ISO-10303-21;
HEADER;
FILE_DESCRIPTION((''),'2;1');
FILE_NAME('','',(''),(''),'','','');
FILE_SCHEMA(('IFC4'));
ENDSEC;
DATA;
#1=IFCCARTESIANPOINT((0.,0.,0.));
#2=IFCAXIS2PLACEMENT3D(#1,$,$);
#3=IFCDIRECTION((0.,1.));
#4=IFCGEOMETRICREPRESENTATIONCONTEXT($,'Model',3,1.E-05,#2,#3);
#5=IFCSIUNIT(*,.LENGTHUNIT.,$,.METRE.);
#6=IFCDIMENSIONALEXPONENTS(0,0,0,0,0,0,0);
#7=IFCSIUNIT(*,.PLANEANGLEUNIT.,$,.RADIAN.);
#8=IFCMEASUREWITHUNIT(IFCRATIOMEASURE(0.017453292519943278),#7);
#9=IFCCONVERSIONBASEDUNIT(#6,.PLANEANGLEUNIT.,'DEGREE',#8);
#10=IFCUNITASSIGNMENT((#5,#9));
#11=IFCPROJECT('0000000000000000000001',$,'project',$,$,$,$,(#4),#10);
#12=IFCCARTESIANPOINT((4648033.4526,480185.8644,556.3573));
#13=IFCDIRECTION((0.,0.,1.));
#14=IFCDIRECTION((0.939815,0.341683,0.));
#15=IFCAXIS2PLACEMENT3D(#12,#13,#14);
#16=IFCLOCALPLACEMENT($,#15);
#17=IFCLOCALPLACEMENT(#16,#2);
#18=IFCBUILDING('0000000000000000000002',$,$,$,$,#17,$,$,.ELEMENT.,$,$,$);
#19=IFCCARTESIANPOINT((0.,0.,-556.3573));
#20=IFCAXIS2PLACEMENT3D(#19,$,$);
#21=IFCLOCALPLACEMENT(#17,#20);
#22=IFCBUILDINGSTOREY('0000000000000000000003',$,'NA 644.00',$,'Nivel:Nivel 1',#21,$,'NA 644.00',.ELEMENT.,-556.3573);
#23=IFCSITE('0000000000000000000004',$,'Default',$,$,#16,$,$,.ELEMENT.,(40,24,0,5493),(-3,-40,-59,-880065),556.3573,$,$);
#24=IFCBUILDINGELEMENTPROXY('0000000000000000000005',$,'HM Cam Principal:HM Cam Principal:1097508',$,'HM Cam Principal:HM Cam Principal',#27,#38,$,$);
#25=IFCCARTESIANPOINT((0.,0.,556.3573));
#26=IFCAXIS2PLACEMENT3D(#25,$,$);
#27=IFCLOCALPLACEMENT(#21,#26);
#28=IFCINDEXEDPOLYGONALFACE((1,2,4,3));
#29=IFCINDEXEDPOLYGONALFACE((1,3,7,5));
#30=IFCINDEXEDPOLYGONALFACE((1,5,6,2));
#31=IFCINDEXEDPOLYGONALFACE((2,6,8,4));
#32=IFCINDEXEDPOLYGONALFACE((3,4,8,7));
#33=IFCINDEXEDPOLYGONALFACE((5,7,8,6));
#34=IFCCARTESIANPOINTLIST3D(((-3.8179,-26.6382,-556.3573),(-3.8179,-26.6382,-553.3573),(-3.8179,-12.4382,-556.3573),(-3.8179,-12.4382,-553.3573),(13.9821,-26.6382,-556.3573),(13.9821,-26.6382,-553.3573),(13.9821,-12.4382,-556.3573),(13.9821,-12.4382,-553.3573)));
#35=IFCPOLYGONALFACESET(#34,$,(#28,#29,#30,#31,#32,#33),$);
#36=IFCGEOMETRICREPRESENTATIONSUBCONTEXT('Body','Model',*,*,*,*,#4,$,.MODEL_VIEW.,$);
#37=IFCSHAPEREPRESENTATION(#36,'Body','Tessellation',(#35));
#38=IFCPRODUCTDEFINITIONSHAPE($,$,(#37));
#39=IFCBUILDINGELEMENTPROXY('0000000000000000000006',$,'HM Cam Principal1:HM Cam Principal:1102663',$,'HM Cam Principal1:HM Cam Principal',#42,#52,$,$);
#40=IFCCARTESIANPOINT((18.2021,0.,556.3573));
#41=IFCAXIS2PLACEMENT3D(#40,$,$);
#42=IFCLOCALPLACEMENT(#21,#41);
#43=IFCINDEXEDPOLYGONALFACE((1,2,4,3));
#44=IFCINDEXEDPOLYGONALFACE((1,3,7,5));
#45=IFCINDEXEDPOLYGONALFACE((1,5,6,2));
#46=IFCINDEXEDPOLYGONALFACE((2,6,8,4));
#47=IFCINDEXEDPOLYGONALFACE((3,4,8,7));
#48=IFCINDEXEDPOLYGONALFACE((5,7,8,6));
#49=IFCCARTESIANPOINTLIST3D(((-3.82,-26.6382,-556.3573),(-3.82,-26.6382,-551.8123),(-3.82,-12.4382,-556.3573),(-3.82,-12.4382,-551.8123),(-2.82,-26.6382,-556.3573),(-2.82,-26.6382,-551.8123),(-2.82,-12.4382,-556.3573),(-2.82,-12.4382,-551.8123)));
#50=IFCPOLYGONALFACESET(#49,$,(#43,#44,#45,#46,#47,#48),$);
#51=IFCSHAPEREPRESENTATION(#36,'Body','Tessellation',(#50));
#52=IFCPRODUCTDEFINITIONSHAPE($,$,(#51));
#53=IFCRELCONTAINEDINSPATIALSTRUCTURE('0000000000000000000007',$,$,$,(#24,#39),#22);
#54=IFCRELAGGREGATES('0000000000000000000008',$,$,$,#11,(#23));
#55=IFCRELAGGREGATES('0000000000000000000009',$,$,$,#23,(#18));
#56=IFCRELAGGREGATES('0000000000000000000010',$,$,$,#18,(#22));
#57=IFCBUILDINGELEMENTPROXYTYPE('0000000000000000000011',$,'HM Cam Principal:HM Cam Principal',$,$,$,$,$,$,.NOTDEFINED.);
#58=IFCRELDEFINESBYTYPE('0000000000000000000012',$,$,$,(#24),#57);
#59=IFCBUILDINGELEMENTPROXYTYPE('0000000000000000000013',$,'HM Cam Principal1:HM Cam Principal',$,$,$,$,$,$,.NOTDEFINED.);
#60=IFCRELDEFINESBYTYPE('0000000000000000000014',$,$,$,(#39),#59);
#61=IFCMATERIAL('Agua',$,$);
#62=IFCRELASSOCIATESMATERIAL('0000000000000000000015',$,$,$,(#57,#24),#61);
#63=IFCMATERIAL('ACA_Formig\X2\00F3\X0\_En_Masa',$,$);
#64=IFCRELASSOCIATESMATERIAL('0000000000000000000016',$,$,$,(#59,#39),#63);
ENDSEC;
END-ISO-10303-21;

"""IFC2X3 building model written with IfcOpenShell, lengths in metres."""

from ifc_helpers import new_model, entity, si_unit, converted_unit, direction, frame, frame_2d, origin, place, context, subcontext, project, spatial, rectangle, extrude, source, transform, mapped, material, type_object, type_shapes, element, save


model = new_model("IFC2X3")

# Units and contexts
model_context = context("Model", 3, precision=1e-05, world=origin(), true_north=direction((0.0, 1.0)))
body_context = subcontext(model_context, "Body", "Model", "MODEL_VIEW")
ifc_project = project(units=[si_unit("LENGTHUNIT", "METRE"), converted_unit("PLANEANGLEUNIT", "DEGREE", entity("IfcRatioMeasure", 0.017453292519943278), si_unit("PLANEANGLEUNIT", "RADIAN"), dimensions=[0, 0, 0, 0, 0, 0, 0])], contexts=[model_context])

# Site, building, storey
site_placement = place(None, frame((4648033.4526, 480185.8644, 556.3573), z_axis=(0.0, 0.0, 1.0), x_axis=(0.939815, 0.341683, 0.0)))
site = spatial("IfcSite", under=ifc_project, at=site_placement, Name="Default", CompositionType="ELEMENT", RefLatitude=(40, 24, 0, 5493), RefLongitude=(-3, -40, -59, -880065), RefElevation=556.3573)
building_placement = place(site_placement, origin())
building = spatial("IfcBuilding", under=site, at=building_placement, CompositionType="ELEMENT")
storey_placement = place(building_placement, frame((0.0, 0.0, -556.3573)))
storey = spatial("IfcBuildingStorey", under=building, at=storey_placement, Name="NA 644.00", ObjectType="Nivel:Nivel 1", LongName="NA 644.00", CompositionType="ELEMENT", Elevation=-556.3573)

# Building element proxies
ifc_material_1 = material(Name="ACA_Formigó_En_Masa")
ifc_material_2 = material(Name="Agua")
building_element_proxy_type_1 = type_object("IfcBuildingElementProxyType", Name="HM Cam Principal:HM Cam Principal", PredefinedType="NOTDEFINED", material=ifc_material_2)
shared_shape_1 = source(origin(), body_context, "Body", "SweptSolid", [
    extrude(rectangle(XDim=14.2, YDim=17.8, at=frame_2d((0.0, 0.0), x_axis=(1.0, 0.0))), frame((5.0821, -19.5382, -556.3573), z_axis=(0.0, 0.0, 1.0), x_axis=(0.0, 1.0, 0.0)), (0.0, 0.0, 1.0), 3.0),
])
type_shapes(building_element_proxy_type_1, [shared_shape_1])
proxy_1_placement = place(storey_placement, frame((0.0, 0.0, 556.3573)))
element("IfcBuildingElementProxy", 1, at=proxy_1_placement, inside=storey, type_object=building_element_proxy_type_1, material=ifc_material_2, Name="HM Cam Principal:HM Cam Principal:1097508", ObjectType="HM Cam Principal:HM Cam Principal", context=body_context, shape_type="MappedRepresentation", body=[
    mapped(shared_shape_1, transform((0.0, 0.0, 0.0), scale=1.0)),
])
building_element_proxy_type_2 = type_object("IfcBuildingElementProxyType", Name="HM Cam Principal1:HM Cam Principal", PredefinedType="NOTDEFINED", material=ifc_material_1)
shared_shape_2 = source(origin(), body_context, "Body", "SweptSolid", [
    extrude(rectangle(XDim=14.2, YDim=1.0, at=frame_2d((0.0, 0.0), x_axis=(1.0, 0.0))), frame((-3.32, -19.5382, -556.3573), z_axis=(0.0, 0.0, 1.0), x_axis=(0.0, 1.0, 0.0)), (0.0, 0.0, 1.0), 4.545),
])
type_shapes(building_element_proxy_type_2, [shared_shape_2])
proxy_2_placement = place(storey_placement, frame((18.2021, 0.0, 556.3573)))
element("IfcBuildingElementProxy", 2, at=proxy_2_placement, inside=storey, type_object=building_element_proxy_type_2, material=ifc_material_1, Name="HM Cam Principal1:HM Cam Principal:1102663", ObjectType="HM Cam Principal1:HM Cam Principal", context=body_context, shape_type="MappedRepresentation", body=[
    mapped(shared_shape_2, transform((0.0, 0.0, 0.0), scale=1.0)),
])

save(model, "model.ifc")
